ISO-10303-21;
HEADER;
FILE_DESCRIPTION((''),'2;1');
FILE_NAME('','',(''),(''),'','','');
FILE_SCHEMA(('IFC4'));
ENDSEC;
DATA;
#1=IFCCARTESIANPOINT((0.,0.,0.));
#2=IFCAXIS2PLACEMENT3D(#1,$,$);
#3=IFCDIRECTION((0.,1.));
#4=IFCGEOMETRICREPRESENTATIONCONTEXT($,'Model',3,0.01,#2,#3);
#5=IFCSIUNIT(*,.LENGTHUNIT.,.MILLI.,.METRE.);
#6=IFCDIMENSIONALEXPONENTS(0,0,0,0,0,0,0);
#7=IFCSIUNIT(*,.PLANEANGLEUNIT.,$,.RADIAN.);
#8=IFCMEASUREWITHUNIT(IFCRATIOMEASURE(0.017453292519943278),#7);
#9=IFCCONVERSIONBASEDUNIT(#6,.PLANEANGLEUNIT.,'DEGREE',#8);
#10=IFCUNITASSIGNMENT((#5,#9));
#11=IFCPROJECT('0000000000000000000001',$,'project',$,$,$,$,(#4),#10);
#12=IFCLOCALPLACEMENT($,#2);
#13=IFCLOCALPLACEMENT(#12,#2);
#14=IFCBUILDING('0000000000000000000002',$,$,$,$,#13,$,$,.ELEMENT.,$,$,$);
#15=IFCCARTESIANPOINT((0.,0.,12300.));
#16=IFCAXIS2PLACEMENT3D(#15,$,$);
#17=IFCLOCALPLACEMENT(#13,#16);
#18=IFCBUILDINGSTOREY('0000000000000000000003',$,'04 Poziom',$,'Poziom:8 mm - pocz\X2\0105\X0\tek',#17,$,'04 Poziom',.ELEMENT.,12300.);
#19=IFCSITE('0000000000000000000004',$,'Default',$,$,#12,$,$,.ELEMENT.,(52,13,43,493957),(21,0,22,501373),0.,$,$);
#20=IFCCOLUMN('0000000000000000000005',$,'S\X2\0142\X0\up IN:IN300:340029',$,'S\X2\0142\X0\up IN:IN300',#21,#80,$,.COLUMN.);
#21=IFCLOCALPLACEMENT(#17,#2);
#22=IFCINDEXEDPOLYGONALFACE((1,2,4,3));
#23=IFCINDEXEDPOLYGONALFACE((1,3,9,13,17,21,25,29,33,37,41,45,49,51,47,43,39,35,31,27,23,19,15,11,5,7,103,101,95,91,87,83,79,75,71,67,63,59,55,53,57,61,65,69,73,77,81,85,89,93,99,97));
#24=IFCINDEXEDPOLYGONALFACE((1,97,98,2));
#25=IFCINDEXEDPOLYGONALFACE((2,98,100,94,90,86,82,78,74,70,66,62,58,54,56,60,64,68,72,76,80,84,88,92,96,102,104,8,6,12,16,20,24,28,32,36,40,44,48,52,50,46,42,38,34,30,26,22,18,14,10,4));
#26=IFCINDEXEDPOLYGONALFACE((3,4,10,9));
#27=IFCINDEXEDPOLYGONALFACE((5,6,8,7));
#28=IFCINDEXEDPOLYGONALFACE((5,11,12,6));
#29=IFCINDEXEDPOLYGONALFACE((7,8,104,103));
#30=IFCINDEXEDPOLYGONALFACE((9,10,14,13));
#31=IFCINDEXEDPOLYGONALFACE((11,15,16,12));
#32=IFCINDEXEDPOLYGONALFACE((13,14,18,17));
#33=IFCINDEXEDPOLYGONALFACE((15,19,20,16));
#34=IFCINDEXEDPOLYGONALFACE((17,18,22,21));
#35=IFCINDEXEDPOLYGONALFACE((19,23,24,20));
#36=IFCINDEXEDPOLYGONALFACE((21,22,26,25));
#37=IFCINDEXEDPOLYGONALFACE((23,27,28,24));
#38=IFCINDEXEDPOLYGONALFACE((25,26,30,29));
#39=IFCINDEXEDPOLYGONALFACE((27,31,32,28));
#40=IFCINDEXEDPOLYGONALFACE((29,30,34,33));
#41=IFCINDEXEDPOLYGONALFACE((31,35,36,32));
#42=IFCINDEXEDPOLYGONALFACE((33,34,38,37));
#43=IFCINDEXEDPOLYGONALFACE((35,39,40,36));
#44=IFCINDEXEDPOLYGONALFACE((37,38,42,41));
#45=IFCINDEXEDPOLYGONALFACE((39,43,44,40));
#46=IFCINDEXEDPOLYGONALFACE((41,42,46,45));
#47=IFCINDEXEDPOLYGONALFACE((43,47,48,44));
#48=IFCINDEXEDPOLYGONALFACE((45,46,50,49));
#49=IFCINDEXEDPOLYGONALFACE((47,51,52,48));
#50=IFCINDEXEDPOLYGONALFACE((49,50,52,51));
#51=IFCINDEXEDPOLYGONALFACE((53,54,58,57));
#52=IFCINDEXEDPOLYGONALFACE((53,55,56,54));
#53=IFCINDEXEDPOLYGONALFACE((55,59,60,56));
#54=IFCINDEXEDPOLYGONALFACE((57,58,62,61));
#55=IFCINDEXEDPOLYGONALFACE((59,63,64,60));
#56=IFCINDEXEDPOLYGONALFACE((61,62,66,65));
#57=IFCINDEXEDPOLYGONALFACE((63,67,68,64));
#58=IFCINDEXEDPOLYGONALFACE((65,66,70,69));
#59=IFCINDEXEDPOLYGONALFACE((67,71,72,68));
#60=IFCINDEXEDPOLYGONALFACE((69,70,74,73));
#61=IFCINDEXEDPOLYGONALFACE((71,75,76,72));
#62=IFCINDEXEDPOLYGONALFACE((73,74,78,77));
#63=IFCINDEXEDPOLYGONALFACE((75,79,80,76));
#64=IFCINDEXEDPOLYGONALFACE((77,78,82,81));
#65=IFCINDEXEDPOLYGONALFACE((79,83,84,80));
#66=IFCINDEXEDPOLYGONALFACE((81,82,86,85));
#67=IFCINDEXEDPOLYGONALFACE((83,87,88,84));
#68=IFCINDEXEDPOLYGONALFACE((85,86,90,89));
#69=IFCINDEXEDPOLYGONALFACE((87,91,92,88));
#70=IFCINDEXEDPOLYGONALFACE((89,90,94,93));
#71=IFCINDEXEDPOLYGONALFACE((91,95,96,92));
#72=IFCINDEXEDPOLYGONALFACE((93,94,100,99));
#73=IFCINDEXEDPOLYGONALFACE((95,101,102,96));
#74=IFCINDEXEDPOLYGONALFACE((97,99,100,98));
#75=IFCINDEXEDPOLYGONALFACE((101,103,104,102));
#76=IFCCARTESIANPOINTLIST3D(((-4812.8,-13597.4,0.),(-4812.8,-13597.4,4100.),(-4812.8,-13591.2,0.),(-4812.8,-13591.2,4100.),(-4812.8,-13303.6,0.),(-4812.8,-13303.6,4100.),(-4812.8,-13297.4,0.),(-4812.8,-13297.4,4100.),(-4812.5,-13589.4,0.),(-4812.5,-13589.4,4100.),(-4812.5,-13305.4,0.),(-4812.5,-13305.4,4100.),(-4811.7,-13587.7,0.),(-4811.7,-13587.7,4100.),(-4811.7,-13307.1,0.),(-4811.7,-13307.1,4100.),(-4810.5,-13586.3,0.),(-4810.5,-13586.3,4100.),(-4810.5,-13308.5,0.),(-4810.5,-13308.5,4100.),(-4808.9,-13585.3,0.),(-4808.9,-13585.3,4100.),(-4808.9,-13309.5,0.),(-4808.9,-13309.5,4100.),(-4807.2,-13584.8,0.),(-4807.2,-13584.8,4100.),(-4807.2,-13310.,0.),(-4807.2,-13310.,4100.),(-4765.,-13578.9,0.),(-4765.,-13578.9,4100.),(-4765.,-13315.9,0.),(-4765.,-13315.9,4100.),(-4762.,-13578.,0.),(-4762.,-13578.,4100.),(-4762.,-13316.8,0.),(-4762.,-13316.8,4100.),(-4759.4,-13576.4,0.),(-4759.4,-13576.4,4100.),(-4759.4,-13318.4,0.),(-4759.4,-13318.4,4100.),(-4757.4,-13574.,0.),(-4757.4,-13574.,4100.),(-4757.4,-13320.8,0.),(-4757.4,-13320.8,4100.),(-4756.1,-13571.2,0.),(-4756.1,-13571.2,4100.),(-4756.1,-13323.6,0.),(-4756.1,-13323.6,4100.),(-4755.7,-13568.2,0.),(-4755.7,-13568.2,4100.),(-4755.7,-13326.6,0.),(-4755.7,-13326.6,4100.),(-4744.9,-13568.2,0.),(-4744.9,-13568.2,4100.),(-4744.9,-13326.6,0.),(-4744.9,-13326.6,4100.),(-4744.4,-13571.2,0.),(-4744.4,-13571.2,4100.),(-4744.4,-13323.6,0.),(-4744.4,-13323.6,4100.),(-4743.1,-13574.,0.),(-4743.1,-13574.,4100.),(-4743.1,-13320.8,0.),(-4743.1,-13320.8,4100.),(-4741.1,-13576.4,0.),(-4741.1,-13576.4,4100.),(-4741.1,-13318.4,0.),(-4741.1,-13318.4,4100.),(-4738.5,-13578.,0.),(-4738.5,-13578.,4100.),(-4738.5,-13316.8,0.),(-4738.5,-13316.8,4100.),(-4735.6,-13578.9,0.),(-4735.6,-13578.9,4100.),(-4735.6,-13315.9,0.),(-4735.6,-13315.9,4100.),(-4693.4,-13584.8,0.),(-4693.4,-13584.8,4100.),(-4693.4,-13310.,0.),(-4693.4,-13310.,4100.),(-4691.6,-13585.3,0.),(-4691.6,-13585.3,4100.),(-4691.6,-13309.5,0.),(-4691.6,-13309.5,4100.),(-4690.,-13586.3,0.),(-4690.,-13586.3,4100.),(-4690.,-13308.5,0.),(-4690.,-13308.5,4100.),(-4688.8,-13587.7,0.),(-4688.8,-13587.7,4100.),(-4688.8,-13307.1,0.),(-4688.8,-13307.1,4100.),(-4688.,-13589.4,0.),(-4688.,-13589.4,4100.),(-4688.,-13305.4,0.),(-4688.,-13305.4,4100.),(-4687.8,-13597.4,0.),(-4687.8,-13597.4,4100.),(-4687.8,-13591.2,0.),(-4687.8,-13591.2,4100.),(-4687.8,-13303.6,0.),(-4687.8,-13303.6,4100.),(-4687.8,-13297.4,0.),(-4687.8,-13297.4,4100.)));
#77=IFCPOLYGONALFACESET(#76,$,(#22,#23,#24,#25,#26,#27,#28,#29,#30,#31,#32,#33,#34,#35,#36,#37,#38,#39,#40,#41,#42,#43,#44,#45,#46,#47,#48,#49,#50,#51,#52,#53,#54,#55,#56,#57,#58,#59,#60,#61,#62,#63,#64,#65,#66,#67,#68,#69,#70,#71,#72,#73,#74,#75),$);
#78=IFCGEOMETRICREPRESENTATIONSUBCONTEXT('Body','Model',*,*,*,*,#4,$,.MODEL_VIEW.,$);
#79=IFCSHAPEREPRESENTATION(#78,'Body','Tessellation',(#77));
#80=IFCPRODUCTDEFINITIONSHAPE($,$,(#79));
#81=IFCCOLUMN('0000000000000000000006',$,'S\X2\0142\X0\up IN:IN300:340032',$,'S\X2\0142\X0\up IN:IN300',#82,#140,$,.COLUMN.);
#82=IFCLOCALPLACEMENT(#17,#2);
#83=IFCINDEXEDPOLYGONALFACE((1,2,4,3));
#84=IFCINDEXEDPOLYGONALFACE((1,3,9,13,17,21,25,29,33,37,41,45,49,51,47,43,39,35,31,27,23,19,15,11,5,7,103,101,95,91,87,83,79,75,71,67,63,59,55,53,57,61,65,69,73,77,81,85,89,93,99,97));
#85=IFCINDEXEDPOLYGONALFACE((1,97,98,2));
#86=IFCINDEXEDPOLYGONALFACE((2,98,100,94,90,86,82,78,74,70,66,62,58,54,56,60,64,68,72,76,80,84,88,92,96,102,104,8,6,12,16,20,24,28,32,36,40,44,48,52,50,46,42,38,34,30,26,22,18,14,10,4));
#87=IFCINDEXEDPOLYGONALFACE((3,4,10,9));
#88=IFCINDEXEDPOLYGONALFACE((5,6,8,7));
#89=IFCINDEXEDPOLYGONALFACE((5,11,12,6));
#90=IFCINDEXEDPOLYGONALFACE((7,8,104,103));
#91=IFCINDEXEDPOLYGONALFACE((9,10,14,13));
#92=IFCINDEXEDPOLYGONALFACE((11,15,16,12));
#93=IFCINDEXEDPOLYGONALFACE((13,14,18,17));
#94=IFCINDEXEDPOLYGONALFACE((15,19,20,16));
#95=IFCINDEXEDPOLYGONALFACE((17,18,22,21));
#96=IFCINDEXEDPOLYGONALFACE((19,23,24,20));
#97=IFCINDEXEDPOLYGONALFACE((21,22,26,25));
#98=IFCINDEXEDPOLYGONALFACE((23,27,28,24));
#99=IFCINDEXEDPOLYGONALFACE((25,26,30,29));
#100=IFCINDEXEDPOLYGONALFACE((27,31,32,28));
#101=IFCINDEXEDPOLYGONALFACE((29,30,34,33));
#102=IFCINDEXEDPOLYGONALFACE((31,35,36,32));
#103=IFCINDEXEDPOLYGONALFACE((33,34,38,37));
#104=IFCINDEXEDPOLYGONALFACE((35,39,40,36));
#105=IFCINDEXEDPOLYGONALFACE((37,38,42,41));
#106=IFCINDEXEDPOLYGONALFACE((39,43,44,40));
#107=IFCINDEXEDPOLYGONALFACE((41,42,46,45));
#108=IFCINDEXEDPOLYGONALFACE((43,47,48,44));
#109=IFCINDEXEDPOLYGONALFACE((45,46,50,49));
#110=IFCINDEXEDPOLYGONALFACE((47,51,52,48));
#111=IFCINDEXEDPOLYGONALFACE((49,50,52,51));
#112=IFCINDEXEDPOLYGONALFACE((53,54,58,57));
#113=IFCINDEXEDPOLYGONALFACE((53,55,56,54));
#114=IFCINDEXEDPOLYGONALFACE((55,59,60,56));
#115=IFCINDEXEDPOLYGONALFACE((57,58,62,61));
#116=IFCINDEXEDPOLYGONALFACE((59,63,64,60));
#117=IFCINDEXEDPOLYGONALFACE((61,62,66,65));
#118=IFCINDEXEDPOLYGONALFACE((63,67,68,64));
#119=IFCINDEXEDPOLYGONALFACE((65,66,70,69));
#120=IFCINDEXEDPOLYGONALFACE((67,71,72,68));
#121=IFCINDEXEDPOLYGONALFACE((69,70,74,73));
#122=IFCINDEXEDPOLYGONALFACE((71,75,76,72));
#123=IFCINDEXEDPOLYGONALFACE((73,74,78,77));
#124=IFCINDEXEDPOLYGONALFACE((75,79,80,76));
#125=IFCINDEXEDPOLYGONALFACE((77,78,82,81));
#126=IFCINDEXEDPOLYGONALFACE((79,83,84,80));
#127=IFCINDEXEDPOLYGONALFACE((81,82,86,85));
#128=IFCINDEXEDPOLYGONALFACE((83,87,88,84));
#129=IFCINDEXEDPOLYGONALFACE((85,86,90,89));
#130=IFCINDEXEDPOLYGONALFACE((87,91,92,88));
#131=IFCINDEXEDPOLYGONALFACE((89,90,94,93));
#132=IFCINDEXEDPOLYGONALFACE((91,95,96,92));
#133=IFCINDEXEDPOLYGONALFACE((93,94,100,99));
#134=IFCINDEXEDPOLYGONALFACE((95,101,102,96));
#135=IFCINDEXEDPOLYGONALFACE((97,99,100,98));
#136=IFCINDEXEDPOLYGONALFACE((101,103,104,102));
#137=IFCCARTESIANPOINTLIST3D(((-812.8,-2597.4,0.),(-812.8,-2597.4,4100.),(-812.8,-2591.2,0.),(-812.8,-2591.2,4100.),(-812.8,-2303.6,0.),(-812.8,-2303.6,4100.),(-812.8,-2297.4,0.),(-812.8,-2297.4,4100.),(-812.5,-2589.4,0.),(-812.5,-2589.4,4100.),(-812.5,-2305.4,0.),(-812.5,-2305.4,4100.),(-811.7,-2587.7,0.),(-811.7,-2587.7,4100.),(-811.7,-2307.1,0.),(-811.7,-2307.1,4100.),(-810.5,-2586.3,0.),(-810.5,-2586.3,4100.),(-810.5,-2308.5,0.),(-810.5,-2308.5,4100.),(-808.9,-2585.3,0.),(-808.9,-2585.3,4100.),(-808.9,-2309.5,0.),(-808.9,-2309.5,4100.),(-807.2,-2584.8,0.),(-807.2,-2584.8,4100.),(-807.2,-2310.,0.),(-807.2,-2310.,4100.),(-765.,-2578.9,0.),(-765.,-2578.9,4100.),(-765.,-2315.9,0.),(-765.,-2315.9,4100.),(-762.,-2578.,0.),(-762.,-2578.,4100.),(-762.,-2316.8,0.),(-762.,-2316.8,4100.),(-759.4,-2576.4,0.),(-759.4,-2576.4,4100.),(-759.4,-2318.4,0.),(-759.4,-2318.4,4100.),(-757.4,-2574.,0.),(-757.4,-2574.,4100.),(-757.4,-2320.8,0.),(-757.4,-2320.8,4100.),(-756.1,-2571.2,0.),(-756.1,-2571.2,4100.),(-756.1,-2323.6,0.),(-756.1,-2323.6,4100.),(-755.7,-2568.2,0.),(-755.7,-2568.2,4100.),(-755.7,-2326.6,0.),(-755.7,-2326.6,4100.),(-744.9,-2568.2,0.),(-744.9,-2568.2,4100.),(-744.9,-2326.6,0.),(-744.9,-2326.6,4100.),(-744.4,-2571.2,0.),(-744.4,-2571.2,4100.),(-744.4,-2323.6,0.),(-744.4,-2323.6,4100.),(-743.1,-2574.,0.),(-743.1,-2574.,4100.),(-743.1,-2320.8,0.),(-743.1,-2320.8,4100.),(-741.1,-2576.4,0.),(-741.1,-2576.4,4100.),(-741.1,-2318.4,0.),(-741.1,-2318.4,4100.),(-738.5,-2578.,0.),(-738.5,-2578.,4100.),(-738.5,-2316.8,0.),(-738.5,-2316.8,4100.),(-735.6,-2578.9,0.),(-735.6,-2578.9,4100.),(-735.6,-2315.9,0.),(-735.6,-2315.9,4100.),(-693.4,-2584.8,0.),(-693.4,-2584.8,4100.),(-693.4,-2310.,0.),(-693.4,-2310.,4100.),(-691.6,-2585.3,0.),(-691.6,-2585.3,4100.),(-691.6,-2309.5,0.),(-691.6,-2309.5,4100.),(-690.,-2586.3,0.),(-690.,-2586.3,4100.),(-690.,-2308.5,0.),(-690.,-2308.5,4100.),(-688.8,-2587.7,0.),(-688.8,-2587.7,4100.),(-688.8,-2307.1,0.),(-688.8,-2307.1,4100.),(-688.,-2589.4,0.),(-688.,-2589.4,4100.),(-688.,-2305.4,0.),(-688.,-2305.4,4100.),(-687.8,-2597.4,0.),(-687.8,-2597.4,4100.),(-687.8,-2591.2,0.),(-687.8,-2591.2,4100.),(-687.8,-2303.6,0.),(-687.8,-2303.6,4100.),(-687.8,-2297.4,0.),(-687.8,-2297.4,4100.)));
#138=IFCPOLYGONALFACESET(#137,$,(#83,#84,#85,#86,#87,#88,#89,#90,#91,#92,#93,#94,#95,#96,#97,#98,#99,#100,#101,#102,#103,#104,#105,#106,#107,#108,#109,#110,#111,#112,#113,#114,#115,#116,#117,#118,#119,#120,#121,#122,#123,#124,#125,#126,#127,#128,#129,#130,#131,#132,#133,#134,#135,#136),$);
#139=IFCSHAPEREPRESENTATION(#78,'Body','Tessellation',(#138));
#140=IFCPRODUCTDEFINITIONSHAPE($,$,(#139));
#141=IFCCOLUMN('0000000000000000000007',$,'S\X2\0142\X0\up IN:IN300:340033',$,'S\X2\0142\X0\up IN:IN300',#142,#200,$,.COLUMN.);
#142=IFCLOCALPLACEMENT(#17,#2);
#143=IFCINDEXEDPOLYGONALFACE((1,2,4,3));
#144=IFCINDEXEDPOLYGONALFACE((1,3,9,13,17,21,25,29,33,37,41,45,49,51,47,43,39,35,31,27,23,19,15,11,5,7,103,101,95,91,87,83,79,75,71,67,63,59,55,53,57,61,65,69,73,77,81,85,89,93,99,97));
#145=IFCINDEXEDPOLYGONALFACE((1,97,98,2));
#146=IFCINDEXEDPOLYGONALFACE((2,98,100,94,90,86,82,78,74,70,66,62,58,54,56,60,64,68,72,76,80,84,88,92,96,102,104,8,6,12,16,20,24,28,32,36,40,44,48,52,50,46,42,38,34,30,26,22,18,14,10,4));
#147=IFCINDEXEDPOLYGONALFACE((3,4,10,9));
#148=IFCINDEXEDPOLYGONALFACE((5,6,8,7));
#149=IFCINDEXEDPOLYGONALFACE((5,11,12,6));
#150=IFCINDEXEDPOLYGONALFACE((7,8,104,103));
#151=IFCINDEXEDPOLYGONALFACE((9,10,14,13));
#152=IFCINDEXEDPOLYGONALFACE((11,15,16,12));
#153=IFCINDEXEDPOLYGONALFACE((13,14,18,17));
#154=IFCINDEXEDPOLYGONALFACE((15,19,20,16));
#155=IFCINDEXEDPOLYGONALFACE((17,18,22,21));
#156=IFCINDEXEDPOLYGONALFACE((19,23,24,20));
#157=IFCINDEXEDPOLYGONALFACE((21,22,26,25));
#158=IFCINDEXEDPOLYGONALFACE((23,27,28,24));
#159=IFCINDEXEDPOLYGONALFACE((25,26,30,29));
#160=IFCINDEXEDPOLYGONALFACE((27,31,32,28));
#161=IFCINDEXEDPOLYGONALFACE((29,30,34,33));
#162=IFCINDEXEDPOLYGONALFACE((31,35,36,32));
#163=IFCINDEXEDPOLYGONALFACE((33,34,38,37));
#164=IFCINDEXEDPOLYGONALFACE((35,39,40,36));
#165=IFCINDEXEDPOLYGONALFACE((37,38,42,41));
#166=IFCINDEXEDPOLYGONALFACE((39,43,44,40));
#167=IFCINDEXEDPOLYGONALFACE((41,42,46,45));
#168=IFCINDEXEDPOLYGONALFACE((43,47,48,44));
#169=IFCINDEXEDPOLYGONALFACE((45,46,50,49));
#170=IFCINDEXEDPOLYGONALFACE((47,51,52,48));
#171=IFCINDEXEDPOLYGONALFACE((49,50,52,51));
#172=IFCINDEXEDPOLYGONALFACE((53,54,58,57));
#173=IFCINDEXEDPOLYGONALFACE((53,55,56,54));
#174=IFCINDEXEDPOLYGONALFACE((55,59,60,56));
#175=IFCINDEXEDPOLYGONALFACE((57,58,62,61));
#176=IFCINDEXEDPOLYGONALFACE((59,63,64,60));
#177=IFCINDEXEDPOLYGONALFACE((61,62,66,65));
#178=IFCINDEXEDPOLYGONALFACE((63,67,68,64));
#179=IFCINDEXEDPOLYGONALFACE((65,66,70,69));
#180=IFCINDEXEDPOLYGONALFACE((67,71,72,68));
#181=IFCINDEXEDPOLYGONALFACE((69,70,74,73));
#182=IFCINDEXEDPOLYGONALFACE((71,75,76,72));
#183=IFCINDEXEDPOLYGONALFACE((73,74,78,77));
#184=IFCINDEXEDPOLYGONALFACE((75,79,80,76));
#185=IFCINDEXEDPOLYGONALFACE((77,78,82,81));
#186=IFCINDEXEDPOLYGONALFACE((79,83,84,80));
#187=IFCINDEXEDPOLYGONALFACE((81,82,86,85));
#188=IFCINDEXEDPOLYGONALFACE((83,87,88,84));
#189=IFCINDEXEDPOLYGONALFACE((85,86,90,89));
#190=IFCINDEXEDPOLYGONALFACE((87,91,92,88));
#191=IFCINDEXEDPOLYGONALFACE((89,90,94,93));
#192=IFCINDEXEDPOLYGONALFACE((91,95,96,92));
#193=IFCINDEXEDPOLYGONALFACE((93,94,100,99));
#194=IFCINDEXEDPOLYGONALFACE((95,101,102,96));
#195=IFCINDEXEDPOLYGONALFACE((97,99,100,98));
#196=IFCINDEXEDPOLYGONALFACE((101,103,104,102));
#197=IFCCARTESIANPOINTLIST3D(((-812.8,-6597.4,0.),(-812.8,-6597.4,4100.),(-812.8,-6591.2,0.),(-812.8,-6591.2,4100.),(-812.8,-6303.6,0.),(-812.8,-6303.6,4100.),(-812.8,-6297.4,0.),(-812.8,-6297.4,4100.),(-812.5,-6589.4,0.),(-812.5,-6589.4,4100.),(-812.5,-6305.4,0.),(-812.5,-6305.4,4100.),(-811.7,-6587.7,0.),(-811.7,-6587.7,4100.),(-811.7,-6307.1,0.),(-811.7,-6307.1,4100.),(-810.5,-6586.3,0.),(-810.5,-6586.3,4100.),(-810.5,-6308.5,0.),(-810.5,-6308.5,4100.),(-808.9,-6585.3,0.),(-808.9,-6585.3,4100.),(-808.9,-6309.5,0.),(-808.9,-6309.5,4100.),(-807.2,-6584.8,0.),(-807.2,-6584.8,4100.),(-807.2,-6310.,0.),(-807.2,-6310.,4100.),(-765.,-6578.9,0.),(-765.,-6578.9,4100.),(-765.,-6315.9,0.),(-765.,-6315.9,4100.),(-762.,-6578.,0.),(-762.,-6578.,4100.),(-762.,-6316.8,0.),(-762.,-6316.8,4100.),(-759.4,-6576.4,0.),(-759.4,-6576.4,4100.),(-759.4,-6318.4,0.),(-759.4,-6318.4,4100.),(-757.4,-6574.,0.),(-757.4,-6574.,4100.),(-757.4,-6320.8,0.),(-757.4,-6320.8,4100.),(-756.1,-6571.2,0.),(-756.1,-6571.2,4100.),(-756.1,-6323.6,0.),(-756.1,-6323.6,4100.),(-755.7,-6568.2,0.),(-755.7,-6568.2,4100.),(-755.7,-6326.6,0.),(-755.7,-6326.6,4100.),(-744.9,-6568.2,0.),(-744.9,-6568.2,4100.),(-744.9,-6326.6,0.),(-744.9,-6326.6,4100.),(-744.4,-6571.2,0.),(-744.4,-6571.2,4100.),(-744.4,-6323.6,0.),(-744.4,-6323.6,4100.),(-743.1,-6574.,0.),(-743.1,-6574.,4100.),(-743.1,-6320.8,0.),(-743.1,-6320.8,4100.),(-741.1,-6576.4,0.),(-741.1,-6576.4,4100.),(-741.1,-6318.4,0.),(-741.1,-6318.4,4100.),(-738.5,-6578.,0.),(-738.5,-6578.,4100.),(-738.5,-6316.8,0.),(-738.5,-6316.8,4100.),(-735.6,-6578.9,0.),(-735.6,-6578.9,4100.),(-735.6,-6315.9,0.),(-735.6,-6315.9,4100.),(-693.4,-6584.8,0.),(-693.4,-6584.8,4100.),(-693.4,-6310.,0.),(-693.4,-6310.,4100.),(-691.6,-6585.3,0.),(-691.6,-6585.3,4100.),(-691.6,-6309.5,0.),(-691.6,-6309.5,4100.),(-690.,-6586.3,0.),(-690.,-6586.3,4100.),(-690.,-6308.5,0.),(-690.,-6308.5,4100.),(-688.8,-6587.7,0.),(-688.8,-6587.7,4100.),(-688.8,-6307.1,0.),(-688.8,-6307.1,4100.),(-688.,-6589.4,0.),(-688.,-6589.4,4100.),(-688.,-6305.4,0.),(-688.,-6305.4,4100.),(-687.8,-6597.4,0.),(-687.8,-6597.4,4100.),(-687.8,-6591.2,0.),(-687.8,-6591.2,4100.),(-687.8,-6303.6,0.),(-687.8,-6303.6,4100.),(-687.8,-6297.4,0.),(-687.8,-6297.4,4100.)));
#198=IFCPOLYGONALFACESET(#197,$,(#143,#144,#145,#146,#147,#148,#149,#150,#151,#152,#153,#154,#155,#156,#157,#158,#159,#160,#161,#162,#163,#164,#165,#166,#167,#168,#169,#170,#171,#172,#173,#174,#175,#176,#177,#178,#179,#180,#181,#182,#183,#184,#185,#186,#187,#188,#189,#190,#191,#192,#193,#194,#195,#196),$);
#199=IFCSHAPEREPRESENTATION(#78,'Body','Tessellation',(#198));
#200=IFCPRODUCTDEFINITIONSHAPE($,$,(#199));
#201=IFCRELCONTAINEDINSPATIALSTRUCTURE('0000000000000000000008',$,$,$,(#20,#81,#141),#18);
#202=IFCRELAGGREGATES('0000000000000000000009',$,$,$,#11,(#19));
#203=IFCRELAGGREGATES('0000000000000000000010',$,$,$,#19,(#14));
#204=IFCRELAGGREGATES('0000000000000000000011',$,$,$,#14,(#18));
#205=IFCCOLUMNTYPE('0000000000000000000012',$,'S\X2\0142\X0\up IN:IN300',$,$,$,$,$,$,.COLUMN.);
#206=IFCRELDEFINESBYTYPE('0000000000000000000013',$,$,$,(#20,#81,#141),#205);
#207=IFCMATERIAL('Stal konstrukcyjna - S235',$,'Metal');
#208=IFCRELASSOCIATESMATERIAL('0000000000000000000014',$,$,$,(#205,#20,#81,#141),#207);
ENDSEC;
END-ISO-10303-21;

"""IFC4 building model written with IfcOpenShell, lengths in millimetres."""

from ifc_helpers import new_model, entity, si_unit, converted_unit, direction, frame, origin, place, context, subcontext, project, spatial, line, arc, indexed_curve, outline, extrude, source, transform, mapped, material, type_object, type_shapes, element, save


model = new_model("IFC4")

# Units and contexts
model_context = context("Model", 3, precision=0.01, world=origin(), true_north=direction((0.0, 1.0)))
body_context = subcontext(model_context, "Body", "Model", "MODEL_VIEW")
ifc_project = project(units=[si_unit("LENGTHUNIT", "METRE", prefix="MILLI"), converted_unit("PLANEANGLEUNIT", "DEGREE", entity("IfcRatioMeasure", 0.017453292519943278), si_unit("PLANEANGLEUNIT", "RADIAN"), dimensions=[0, 0, 0, 0, 0, 0, 0])], contexts=[model_context])

# Site, building, storey
site_placement = place(None, origin())
site = spatial("IfcSite", under=ifc_project, at=site_placement, Name="Default", CompositionType="ELEMENT", RefLatitude=(52, 13, 43, 493957), RefLongitude=(21, 0, 22, 501373), RefElevation=0.0)
building_placement = place(site_placement, origin())
building = spatial("IfcBuilding", under=site, at=building_placement, CompositionType="ELEMENT")
storey_placement = place(building_placement, frame((0.0, 0.0, 12300.0)))
storey = spatial("IfcBuildingStorey", under=building, at=storey_placement, Name="04 Poziom", ObjectType="Poziom:8 mm - początek", LongName="04 Poziom", CompositionType="ELEMENT", Elevation=12300.0)

# Columns
ifc_material = material(Name="Stal konstrukcyjna - S235", Category="Metal")
column_type = type_object("IfcColumnType", Name="Słup IN:IN300", PredefinedType="COLUMN", material=ifc_material)
shared_shape_1 = source(origin(), body_context, "Body", "SweptSolid", [
    extrude(outline(indexed_curve([(143.8, -62.5), (150.0, -62.5), (150.0, 62.5), (143.8, 62.5), (139.6, 60.9), (137.4, 56.9), (131.5, 14.7), (127.9, 8.1), (120.8, 5.4), (-120.8, 5.4), (-127.9, 8.1), (-131.5, 14.7), (-137.4, 56.9), (-139.6, 60.9), (-143.8, 62.5), (-150.0, 62.5), (-150.0, -62.5), (-143.8, -62.5), (-139.6, -60.9), (-137.4, -56.9), (-131.5, -14.7), (-127.9, -8.1), (-120.8, -5.4), (120.8, -5.4), (127.9, -8.1), (131.5, -14.7), (137.4, -56.9), (139.6, -60.9)], segments=[line(1, 2, 3, 4), arc(4, 5, 6), line(6, 7), arc(7, 8, 9), line(9, 10), arc(10, 11, 12), line(12, 13), arc(13, 14, 15), line(15, 16, 17, 18), arc(18, 19, 20), line(20, 21), arc(21, 22, 23), line(23, 24), arc(24, 25, 26), line(26, 27), arc(27, 28, 1)], self_intersect=False)), frame((0.0, 0.0, 12300.0), z_axis=(0.0, 0.0, 1.0), x_axis=(0.0, -1.0, 0.0)), (0.0, 0.0, 1.0), 4100.0),
])
type_shapes(column_type, [shared_shape_1])
for number, where, name in (
    (1, (-4750.3, -13447.4, -12300.0), "Słup IN:IN300:340029"),
    (2, (-750.3, -2447.4, -12300.0), "Słup IN:IN300:340032"),
    (3, (-750.3, -6447.4, -12300.0), "Słup IN:IN300:340033"),
):
    element("IfcColumn", number, at=place(storey_placement, frame(where)), inside=storey, type_object=column_type, material=ifc_material, Name=name, ObjectType="Słup IN:IN300", PredefinedType="COLUMN", context=body_context, shape_type="MappedRepresentation", body=[
        mapped(shared_shape_1, transform((0.0, 0.0, 0.0), scale=1.0)),
    ])

save(model, "model.ifc")
